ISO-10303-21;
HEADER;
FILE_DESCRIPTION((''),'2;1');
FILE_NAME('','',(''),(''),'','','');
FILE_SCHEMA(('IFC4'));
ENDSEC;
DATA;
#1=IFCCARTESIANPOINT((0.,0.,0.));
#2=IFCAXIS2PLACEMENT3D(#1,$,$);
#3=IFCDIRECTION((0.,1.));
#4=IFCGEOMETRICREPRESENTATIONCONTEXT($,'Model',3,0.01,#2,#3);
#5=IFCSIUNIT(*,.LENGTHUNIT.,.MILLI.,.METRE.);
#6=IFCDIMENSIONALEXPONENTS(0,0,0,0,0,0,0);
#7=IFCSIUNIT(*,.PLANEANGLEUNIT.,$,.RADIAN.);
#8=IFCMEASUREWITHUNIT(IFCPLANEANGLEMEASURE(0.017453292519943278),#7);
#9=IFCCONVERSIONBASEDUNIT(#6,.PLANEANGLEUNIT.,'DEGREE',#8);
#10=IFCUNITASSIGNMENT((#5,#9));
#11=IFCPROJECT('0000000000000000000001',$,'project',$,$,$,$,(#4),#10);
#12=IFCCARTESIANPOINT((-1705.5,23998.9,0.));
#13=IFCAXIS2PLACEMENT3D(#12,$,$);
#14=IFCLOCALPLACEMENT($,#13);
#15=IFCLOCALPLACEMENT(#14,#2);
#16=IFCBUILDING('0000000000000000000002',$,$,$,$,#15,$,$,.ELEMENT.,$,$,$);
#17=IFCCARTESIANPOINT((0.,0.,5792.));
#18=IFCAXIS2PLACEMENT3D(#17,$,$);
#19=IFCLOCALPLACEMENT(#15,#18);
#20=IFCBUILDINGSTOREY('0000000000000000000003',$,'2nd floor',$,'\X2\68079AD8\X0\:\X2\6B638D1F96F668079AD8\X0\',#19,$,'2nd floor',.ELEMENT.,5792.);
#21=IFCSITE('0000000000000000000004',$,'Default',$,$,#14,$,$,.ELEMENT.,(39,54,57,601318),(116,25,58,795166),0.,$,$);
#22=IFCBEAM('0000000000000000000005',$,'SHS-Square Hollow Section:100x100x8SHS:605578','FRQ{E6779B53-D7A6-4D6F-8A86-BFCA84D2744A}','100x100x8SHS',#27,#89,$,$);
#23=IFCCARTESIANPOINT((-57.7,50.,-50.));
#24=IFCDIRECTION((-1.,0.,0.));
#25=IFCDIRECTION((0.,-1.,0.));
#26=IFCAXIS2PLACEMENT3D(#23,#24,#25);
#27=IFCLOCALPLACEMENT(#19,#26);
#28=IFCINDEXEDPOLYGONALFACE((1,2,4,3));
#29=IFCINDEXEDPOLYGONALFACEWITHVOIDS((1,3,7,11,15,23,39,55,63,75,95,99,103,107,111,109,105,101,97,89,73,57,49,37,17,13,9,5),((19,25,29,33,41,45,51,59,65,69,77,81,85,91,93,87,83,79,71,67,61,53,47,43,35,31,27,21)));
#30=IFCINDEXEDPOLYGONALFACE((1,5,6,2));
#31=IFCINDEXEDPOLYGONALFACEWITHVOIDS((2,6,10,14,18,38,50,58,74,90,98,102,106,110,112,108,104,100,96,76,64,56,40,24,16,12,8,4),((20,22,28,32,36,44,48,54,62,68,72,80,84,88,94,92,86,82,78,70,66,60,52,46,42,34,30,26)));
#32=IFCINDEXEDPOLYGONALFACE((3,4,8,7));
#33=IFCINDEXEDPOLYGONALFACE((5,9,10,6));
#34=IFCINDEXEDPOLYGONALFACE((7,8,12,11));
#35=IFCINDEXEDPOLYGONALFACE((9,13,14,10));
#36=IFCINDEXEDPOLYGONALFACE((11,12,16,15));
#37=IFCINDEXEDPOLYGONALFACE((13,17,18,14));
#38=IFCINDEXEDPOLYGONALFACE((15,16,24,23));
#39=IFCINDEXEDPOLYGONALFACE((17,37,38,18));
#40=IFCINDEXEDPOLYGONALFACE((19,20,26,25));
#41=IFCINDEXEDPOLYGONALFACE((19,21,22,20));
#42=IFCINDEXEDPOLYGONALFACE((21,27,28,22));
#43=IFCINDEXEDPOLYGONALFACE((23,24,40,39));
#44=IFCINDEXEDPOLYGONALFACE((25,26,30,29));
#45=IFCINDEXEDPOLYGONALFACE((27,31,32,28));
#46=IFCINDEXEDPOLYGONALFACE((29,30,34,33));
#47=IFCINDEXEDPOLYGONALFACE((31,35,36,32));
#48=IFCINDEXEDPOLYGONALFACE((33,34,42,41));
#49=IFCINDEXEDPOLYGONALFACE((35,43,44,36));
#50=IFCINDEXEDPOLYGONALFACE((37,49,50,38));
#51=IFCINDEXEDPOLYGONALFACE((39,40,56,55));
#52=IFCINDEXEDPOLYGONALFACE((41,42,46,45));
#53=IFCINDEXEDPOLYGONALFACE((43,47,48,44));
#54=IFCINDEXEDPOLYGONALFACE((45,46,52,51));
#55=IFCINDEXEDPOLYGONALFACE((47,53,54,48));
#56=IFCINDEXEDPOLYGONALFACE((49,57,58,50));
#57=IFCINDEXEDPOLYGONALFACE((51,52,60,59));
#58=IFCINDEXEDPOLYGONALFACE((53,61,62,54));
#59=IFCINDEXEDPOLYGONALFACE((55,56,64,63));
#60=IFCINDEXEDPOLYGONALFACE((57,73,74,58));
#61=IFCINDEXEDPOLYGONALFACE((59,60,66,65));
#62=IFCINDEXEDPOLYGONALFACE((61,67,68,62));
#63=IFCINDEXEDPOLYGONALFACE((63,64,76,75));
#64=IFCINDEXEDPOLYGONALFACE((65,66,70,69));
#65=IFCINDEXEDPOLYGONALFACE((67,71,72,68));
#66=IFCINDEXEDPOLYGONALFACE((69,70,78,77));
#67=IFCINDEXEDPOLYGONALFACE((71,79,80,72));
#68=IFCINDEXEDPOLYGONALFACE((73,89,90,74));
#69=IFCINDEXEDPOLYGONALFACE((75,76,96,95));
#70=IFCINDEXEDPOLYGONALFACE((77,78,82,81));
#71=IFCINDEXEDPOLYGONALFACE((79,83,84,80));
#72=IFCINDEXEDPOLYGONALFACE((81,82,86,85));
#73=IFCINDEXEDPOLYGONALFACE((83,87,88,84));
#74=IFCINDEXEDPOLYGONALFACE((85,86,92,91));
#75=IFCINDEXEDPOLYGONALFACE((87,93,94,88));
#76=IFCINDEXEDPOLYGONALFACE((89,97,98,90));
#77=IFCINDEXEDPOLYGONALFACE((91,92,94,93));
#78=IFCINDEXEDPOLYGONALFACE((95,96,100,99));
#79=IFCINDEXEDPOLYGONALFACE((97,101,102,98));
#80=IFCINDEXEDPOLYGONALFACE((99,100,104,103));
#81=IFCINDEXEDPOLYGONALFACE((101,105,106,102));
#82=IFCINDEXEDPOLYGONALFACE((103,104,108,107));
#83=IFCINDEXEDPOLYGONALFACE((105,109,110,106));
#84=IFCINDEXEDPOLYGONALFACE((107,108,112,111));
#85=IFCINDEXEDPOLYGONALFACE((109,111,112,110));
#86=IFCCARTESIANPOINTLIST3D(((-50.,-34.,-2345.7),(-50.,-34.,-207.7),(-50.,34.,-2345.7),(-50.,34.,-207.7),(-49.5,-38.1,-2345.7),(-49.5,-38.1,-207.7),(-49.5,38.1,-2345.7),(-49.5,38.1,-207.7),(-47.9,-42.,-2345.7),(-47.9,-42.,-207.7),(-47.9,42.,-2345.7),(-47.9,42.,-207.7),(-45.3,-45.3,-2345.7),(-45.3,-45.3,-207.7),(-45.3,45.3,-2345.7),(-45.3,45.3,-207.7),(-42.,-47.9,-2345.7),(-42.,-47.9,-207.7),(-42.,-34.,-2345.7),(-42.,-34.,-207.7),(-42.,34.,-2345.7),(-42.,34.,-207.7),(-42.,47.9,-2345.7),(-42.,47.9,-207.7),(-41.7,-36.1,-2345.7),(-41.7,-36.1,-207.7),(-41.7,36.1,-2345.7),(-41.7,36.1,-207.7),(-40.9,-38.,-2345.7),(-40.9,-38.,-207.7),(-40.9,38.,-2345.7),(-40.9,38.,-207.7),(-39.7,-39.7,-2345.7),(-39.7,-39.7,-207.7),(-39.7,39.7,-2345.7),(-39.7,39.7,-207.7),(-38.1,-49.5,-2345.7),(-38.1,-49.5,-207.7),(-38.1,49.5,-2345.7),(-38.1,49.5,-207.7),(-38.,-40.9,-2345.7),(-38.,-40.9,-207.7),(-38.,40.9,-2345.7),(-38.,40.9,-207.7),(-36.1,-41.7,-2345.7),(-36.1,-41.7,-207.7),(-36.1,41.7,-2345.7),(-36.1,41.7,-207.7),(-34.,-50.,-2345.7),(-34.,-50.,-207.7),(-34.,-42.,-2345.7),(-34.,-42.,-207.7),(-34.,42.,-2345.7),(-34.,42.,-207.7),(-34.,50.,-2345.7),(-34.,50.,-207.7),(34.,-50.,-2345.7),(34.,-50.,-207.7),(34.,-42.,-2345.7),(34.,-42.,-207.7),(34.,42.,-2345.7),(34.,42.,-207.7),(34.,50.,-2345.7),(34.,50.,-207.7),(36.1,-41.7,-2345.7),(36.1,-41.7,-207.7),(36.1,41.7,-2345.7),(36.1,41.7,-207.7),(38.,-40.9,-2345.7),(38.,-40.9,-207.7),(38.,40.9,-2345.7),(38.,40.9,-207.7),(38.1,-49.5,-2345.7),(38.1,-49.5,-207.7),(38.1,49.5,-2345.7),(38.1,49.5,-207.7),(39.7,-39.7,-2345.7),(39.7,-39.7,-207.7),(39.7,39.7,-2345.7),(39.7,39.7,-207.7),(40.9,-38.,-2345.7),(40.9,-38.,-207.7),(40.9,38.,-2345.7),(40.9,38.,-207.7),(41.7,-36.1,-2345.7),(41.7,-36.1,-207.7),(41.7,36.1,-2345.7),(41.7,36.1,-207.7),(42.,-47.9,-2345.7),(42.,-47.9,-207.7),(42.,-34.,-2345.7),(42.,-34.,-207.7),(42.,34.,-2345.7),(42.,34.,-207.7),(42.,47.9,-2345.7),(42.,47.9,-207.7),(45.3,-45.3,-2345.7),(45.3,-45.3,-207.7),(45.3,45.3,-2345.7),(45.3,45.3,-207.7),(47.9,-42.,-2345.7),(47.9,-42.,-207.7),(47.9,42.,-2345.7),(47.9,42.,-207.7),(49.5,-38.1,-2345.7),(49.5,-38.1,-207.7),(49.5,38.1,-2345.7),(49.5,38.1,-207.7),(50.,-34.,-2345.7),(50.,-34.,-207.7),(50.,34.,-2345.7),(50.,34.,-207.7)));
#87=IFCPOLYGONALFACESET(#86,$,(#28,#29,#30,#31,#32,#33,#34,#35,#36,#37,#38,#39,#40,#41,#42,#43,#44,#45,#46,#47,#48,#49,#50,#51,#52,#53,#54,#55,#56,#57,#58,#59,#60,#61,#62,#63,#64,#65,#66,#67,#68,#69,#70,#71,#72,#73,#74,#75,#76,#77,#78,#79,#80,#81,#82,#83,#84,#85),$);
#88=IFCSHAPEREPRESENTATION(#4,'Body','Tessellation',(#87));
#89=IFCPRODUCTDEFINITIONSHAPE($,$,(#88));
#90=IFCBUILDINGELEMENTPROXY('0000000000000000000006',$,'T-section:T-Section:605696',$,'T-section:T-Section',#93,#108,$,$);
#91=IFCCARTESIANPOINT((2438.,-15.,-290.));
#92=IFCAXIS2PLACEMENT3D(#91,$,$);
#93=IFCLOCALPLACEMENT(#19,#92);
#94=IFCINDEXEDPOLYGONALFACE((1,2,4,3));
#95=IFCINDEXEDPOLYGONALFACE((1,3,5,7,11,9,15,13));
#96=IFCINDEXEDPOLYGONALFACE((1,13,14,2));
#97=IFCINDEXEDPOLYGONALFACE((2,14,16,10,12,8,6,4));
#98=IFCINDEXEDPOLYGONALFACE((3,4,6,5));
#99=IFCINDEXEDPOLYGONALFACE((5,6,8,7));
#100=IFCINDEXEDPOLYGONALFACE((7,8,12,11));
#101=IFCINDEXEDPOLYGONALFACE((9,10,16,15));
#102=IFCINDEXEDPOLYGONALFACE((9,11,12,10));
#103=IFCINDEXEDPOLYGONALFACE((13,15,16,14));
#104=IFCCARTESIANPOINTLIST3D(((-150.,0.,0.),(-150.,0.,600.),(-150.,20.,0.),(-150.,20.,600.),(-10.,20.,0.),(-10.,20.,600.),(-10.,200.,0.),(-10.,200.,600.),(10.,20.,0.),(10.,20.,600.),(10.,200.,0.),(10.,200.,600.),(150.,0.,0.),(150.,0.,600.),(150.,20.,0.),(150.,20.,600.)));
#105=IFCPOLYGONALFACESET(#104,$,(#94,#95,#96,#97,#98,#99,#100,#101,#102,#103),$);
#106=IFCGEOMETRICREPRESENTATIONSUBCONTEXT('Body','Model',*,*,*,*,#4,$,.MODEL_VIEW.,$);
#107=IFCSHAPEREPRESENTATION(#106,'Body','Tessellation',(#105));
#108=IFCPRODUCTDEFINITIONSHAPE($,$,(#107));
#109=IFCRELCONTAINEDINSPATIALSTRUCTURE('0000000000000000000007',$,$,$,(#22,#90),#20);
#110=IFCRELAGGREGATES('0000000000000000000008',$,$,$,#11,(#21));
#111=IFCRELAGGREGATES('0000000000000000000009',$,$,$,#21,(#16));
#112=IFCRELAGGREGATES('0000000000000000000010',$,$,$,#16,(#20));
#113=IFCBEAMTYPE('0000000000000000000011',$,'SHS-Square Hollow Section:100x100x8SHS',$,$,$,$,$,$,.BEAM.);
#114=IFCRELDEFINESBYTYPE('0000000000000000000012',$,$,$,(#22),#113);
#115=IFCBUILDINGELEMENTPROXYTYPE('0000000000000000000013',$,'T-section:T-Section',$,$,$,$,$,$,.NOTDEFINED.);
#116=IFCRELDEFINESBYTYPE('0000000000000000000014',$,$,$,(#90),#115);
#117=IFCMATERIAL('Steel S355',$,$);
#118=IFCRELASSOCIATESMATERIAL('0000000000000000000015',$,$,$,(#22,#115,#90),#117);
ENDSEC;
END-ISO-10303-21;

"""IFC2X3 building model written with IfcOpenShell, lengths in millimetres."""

from ifc_helpers import new_model, entity, si_unit, converted_unit, direction, frame, origin, origin_2d, place, context, subcontext, project, spatial, polyline, hollow_rectangle, outline, extrude, clip, halfspace, source, transform, mapped, material, type_object, type_shapes, element, save


model = new_model("IFC2X3")

# Units and contexts
model_context = context("Model", 3, precision=0.01, world=origin(), true_north=direction((0.0, 1.0)))
body_context = subcontext(model_context, "Body", "Model", "MODEL_VIEW")
ifc_project = project(units=[si_unit("LENGTHUNIT", "METRE", prefix="MILLI"), converted_unit("PLANEANGLEUNIT", "DEGREE", entity("IfcPlaneAngleMeasure", 0.017453292519943278), si_unit("PLANEANGLEUNIT", "RADIAN"), dimensions=[0, 0, 0, 0, 0, 0, 0])], contexts=[model_context])

# Site, building, storey
site_placement = place(None, frame((-1705.5, 23998.9, 0.0)))
site = spatial("IfcSite", under=ifc_project, at=site_placement, Name="Default", CompositionType="ELEMENT", RefLatitude=(39, 54, 57, 601318), RefLongitude=(116, 25, 58, 795166), RefElevation=0.0)
building_placement = place(site_placement, origin())
building = spatial("IfcBuilding", under=site, at=building_placement, CompositionType="ELEMENT")
storey_placement = place(building_placement, frame((0.0, 0.0, 5792.0)))
storey = spatial("IfcBuildingStorey", under=building, at=storey_placement, Name="2nd floor", ObjectType="标高:正负零标高", LongName="2nd floor", CompositionType="ELEMENT", Elevation=5792.0)

# Beam
ifc_material_1 = material(Name="Steel S355")
beam_type_1 = type_object("IfcBeamType", Name="SHS-Square Hollow Section:100x100x8SHS", PredefinedType="BEAM")
beam_1_placement = place(storey_placement, frame((-57.7, 50.0, -50.0), z_axis=(-1.0, 0.0, 0.0), x_axis=(0.0, -1.0, 0.0)))
element("IfcBeam", 1, at=beam_1_placement, inside=storey, type_object=beam_type_1, material=ifc_material_1, Name="SHS-Square Hollow Section:100x100x8SHS:605578", Description="FRQ{E6779B53-D7A6-4D6F-8A86-BFCA84D2744A}", ObjectType="100x100x8SHS", context=model_context, shape_type="Clipping", body=[
    clip(clip(extrude(hollow_rectangle(XDim=100.0, YDim=100.0, WallThickness=8.0, InnerFilletRadius=8.0, OuterFilletRadius=16.0, at=origin_2d()), origin(), (0.0, 0.0, -1.0), 2551.4), halfspace(frame((50.0, -5742.0, -207.7), z_axis=(0.0, 0.0, -1.0), x_axis=(-1.0, 0.0, 0.0)), True)), halfspace(frame((50.0, -5742.0, -2345.7), z_axis=(0.0, 0.0, 1.0), x_axis=(1.0, 0.0, 0.0)), True)),
])

# Building element proxy
building_element_proxy_type_1 = type_object("IfcBuildingElementProxyType", Name="T-section:T-Section", PredefinedType="NOTDEFINED", material=ifc_material_1)
shared_shape_1 = source(origin(), body_context, "Body", "SweptSolid", [
    extrude(outline(polyline([(-140.0, 10.0), (-140.0, -10.0), (40.0, -10.0), (40.0, -150.0), (60.0, -150.0), (60.0, 150.0), (40.0, 150.0), (40.0, 10.0), (-140.0, 10.0)])), frame((0.0, 60.0, 0.0), z_axis=(0.0, 0.0, -1.0), x_axis=(0.0, -1.0, 0.0)), (0.0, 0.0, -1.0), 600.0),
])
type_shapes(building_element_proxy_type_1, [shared_shape_1])
proxy_placement = place(storey_placement, frame((2438.0, -15.0, -290.0)))
element("IfcBuildingElementProxy", 2, at=proxy_placement, inside=storey, type_object=building_element_proxy_type_1, material=ifc_material_1, Name="T-section:T-Section:605696", ObjectType="T-section:T-Section", context=body_context, shape_type="MappedRepresentation", body=[
    mapped(shared_shape_1, transform((0.0, 0.0, 0.0), scale=1.0)),
])

save(model, "model.ifc")
